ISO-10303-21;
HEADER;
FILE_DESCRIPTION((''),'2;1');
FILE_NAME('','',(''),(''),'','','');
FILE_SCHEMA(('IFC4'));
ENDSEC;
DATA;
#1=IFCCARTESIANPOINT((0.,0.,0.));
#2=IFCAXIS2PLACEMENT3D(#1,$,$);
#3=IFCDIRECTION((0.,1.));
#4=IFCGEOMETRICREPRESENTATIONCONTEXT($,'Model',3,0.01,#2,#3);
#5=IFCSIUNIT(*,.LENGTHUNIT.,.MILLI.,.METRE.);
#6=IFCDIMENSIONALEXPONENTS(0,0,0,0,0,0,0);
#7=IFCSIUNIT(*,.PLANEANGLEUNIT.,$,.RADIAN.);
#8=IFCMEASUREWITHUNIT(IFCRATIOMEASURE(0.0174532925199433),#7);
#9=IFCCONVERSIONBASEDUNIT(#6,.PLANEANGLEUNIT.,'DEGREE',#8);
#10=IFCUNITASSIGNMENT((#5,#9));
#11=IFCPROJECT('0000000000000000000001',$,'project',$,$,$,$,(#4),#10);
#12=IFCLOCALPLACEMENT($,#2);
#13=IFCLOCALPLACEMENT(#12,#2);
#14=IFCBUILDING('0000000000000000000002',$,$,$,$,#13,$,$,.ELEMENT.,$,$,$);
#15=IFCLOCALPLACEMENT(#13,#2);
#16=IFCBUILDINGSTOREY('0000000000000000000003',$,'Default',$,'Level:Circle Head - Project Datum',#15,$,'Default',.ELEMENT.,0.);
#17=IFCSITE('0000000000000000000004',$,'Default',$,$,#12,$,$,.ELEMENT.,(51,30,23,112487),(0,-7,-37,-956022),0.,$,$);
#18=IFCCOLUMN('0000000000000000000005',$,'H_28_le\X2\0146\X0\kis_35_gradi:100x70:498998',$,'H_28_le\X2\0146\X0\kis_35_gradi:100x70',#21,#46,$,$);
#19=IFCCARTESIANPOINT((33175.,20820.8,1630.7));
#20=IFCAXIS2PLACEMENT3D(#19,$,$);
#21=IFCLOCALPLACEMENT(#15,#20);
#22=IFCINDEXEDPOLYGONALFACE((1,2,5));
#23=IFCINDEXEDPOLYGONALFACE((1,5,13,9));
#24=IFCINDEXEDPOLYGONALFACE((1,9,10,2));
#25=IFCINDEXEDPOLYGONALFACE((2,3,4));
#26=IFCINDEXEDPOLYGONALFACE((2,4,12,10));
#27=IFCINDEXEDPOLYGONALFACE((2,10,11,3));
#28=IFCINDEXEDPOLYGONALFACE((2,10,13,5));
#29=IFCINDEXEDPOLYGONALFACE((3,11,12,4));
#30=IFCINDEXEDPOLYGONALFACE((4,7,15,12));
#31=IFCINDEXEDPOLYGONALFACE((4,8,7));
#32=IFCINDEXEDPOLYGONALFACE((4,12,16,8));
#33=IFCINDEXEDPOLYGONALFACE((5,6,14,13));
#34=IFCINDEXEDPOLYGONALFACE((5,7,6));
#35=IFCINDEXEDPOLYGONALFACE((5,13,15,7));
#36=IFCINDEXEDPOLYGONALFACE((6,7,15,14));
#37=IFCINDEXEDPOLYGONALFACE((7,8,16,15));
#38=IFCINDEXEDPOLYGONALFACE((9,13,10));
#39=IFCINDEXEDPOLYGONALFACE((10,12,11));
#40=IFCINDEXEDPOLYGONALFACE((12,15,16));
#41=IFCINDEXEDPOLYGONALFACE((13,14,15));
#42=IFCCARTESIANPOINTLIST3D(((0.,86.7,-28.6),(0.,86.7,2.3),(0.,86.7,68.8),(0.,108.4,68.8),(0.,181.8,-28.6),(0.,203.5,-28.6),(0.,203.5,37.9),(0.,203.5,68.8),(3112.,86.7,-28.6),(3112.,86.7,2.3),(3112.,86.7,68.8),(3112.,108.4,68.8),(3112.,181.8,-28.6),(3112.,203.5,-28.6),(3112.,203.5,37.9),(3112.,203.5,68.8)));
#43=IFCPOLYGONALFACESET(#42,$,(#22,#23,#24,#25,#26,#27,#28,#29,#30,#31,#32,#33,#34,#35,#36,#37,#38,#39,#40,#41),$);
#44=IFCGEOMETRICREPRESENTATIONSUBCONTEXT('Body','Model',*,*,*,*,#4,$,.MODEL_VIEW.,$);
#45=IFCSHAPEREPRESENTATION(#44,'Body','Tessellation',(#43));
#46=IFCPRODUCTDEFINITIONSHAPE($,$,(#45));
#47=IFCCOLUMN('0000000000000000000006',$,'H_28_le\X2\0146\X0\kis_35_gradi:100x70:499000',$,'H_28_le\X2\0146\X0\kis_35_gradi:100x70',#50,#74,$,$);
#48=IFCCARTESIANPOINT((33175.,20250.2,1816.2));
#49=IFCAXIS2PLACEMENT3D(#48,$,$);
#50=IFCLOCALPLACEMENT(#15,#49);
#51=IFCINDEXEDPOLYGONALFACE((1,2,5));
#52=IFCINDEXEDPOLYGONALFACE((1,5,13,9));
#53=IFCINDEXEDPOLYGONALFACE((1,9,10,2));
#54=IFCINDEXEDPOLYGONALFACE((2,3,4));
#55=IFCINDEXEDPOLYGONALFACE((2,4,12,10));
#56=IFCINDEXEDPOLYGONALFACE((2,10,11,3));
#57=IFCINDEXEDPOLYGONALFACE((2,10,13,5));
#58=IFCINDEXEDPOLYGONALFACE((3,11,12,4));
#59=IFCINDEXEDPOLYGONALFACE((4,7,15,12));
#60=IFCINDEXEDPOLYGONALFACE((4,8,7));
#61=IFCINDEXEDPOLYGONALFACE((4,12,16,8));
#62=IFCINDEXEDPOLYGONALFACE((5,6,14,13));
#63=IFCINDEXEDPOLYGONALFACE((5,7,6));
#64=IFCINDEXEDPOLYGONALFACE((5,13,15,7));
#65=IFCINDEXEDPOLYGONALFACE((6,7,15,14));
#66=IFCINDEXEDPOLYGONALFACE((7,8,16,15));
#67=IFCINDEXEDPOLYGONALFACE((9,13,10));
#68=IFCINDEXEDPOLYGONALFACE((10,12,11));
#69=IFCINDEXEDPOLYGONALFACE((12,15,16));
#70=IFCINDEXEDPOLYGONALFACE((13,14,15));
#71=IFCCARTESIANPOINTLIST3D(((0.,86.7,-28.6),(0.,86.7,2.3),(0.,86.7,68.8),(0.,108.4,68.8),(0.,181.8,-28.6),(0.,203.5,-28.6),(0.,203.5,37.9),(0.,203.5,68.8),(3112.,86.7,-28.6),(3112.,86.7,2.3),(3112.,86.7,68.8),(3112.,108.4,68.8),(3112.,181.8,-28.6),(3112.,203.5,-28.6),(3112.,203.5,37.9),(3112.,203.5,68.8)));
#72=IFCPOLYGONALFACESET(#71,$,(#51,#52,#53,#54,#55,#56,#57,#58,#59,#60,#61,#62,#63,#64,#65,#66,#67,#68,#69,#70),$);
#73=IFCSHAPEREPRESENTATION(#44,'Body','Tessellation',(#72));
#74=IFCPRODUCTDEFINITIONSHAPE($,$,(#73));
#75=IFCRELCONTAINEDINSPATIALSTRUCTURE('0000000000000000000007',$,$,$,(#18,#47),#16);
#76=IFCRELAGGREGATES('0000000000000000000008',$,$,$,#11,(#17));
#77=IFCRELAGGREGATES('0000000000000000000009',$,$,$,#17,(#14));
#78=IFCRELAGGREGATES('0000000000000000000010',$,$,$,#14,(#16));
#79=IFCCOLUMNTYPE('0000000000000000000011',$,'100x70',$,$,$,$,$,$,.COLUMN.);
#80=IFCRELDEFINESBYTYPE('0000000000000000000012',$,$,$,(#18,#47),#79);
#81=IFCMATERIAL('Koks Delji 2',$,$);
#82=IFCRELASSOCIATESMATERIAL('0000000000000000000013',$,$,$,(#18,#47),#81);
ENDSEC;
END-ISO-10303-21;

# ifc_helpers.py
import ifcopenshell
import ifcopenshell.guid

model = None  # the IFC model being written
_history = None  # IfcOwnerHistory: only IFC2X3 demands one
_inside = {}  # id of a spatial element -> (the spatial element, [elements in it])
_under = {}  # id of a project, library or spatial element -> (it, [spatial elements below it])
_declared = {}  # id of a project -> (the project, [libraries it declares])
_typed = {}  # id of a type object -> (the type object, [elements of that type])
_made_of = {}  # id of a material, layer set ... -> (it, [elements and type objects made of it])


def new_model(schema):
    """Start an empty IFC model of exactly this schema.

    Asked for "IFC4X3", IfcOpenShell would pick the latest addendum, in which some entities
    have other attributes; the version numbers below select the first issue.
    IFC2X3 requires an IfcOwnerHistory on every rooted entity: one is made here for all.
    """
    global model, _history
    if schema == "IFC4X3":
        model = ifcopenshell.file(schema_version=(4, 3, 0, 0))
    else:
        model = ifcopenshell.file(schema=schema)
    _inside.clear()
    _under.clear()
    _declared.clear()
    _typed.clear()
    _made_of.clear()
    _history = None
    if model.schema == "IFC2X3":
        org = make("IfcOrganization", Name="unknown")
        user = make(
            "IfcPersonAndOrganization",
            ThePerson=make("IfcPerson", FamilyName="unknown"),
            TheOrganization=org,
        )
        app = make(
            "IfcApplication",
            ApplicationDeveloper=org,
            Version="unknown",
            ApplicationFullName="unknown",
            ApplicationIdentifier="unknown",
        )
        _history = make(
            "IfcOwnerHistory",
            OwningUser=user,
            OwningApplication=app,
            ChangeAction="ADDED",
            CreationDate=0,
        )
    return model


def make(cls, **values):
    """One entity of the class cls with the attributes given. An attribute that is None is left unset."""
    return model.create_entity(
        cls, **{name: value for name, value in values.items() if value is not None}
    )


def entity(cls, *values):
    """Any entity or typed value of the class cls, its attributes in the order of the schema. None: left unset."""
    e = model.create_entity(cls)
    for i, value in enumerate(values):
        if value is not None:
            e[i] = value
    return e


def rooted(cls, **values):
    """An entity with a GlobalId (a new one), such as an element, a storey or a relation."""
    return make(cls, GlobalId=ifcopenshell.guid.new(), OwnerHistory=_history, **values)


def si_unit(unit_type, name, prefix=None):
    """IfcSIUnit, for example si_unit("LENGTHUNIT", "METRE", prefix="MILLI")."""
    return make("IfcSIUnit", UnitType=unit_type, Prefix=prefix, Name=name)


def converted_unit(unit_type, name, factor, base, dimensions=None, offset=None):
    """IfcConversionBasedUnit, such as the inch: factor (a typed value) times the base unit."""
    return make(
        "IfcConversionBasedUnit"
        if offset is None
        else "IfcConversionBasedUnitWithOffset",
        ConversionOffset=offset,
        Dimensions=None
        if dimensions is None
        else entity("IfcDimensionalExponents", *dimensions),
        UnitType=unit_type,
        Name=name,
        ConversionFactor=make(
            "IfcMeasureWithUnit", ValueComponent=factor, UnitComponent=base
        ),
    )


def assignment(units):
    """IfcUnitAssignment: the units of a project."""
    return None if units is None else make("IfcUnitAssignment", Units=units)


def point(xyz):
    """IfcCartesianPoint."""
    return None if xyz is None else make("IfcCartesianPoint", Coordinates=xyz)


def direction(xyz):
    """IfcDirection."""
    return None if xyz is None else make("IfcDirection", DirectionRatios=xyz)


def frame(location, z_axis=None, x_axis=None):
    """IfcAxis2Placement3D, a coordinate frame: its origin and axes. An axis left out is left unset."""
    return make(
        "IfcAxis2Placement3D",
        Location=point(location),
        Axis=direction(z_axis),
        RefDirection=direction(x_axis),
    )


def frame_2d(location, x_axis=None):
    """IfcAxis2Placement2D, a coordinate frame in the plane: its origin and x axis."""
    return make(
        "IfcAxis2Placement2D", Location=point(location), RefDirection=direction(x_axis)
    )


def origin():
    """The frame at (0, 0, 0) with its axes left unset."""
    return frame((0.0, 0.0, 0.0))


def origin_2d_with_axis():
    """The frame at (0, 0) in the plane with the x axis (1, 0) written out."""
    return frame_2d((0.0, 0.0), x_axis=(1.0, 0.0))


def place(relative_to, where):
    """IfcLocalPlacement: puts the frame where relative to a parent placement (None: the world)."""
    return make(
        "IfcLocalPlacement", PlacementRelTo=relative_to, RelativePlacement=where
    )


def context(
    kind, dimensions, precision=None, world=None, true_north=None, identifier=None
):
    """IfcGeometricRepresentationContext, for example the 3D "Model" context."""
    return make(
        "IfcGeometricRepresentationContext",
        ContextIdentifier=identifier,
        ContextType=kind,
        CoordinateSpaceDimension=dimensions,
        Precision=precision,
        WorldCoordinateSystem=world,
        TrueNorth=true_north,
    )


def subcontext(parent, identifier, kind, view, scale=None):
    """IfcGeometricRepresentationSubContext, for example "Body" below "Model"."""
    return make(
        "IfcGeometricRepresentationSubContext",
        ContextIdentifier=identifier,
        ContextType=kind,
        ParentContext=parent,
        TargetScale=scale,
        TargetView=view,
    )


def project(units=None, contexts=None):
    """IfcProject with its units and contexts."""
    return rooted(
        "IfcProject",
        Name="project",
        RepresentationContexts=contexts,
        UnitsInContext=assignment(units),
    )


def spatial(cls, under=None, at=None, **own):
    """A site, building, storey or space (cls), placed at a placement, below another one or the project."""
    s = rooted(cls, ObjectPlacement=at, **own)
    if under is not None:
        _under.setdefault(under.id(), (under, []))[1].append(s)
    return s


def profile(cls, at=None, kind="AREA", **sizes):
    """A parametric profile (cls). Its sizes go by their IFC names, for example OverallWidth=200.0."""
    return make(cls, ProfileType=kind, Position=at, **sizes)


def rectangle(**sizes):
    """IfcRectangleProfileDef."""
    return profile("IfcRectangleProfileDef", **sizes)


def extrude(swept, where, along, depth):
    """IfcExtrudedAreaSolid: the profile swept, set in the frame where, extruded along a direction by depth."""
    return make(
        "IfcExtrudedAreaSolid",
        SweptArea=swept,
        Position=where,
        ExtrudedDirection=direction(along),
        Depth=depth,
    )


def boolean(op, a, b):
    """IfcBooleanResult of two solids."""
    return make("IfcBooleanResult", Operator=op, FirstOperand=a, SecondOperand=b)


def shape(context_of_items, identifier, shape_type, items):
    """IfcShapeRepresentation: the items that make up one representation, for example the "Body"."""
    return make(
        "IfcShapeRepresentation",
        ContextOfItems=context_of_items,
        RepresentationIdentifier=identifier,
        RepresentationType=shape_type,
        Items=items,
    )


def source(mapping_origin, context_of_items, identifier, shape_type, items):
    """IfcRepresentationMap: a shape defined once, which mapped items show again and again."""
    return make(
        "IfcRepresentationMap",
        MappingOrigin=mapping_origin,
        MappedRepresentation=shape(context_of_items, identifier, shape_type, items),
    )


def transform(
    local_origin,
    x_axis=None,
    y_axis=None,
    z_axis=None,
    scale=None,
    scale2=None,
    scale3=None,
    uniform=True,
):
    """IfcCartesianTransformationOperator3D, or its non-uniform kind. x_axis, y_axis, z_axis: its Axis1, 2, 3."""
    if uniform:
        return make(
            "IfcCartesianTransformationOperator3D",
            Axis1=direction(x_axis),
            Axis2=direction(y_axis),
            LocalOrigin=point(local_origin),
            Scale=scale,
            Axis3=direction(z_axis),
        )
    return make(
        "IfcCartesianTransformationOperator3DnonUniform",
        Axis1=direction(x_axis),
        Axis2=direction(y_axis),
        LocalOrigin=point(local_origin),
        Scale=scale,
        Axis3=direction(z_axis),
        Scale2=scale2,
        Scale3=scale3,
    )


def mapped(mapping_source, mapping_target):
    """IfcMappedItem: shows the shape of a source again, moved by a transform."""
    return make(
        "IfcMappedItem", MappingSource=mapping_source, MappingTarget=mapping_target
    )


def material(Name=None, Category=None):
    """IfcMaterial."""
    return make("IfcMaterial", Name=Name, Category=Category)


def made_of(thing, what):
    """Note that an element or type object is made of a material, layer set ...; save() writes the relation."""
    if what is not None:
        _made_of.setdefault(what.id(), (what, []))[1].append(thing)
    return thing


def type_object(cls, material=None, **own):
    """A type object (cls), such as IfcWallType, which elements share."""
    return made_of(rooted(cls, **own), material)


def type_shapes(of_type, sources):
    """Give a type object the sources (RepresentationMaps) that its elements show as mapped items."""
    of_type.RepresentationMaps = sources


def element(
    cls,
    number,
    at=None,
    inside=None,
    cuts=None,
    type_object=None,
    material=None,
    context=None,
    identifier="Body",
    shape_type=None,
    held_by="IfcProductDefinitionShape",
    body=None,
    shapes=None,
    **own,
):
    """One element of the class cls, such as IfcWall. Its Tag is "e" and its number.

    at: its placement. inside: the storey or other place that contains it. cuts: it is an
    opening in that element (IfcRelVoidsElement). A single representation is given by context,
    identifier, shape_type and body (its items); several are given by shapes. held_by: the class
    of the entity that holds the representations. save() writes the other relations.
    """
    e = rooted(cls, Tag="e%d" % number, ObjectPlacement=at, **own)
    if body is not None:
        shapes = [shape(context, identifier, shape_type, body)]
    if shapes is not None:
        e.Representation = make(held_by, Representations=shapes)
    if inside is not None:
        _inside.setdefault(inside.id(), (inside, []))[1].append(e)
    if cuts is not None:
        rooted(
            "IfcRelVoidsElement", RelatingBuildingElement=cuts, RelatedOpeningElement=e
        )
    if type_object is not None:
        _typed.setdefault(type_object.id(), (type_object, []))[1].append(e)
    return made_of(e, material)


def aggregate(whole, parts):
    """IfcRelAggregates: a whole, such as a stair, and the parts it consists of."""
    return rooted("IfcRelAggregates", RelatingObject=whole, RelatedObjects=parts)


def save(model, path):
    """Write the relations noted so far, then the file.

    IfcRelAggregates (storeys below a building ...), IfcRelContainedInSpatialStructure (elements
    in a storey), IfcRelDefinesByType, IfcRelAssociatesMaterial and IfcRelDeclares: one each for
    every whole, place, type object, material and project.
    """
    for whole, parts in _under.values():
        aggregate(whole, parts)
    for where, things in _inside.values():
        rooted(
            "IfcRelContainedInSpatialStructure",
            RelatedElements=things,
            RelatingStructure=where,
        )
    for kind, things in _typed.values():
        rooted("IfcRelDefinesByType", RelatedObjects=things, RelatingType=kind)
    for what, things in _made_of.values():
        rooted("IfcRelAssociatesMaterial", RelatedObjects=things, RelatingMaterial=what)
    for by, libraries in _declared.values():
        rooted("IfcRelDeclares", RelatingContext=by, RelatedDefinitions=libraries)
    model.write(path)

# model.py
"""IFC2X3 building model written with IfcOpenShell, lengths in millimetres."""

from ifc_helpers import new_model, entity, si_unit, converted_unit, direction, frame, frame_2d, origin, origin_2d_with_axis, place, context, subcontext, project, spatial, rectangle, extrude, boolean, source, transform, mapped, material, type_object, type_shapes, element, save


model = new_model("IFC2X3")

# Units and contexts
model_context = context("Model", 3, precision=0.01, world=origin(), true_north=direction((0.0, 1.0)))
body_context = subcontext(model_context, "Body", "Model", "MODEL_VIEW")
ifc_project = project(units=[si_unit("LENGTHUNIT", "METRE", prefix="MILLI"), converted_unit("PLANEANGLEUNIT", "DEGREE", entity("IfcRatioMeasure", 0.0174532925199433), si_unit("PLANEANGLEUNIT", "RADIAN"), dimensions=[0, 0, 0, 0, 0, 0, 0])], contexts=[model_context])

# Site, building, storey
site_placement = place(None, origin())
site = spatial("IfcSite", under=ifc_project, at=site_placement, Name="Default", CompositionType="ELEMENT", RefLatitude=(51, 30, 23, 112487), RefLongitude=(0, -7, -37, -956022), RefElevation=0.0)
building_placement = place(site_placement, origin())
building = spatial("IfcBuilding", under=site, at=building_placement, CompositionType="ELEMENT")
storey_placement = place(building_placement, origin())
storey = spatial("IfcBuildingStorey", under=building, at=storey_placement, Name="Default", ObjectType="Level:Circle Head - Project Datum", LongName="Default", CompositionType="ELEMENT", Elevation=0.0)

# Columns
ifc_material_1 = material(Name="Koks Delji 2")
column_type = type_object("IfcColumnType", Name="100x70", PredefinedType="COLUMN")
shared_shape_1 = source(origin(), body_context, "Body", "CSG", [
    boolean("DIFFERENCE", extrude(rectangle(XDim=3112.0, YDim=116.7, at=origin_2d_with_axis()), frame((1556.0, 145.1, -28.6)), (0.0, 0.0, 1.0), 97.5), extrude(rectangle(XDim=70.0, YDim=100.0, at=frame_2d((0.0, 0.0), x_axis=(0.0, 1.0))), frame((3112.0, 145.1, 20.1), z_axis=(1.0, 0.0, 0.0), x_axis=(0.0, 0.951057, -0.309017)), (0.0, 0.0, -1.0), 3112.0)),
])
type_shapes(column_type, [shared_shape_1])
for number, where, name in (
    (1, (33175.0, 20820.8, 1630.7), "H_28_leņkis_35_gradi:100x70:498998"),
    (2, (33175.0, 20250.2, 1816.2), "H_28_leņkis_35_gradi:100x70:499000"),
):
    element("IfcColumn", number, at=place(storey_placement, frame(where)), inside=storey, type_object=column_type, material=ifc_material_1, Name=name, ObjectType="H_28_leņkis_35_gradi:100x70", context=body_context, shape_type="MappedRepresentation", body=[
        mapped(shared_shape_1, transform((0.0, 0.0, 0.0), scale=1.0)),
    ])

save(model, "model.ifc")
